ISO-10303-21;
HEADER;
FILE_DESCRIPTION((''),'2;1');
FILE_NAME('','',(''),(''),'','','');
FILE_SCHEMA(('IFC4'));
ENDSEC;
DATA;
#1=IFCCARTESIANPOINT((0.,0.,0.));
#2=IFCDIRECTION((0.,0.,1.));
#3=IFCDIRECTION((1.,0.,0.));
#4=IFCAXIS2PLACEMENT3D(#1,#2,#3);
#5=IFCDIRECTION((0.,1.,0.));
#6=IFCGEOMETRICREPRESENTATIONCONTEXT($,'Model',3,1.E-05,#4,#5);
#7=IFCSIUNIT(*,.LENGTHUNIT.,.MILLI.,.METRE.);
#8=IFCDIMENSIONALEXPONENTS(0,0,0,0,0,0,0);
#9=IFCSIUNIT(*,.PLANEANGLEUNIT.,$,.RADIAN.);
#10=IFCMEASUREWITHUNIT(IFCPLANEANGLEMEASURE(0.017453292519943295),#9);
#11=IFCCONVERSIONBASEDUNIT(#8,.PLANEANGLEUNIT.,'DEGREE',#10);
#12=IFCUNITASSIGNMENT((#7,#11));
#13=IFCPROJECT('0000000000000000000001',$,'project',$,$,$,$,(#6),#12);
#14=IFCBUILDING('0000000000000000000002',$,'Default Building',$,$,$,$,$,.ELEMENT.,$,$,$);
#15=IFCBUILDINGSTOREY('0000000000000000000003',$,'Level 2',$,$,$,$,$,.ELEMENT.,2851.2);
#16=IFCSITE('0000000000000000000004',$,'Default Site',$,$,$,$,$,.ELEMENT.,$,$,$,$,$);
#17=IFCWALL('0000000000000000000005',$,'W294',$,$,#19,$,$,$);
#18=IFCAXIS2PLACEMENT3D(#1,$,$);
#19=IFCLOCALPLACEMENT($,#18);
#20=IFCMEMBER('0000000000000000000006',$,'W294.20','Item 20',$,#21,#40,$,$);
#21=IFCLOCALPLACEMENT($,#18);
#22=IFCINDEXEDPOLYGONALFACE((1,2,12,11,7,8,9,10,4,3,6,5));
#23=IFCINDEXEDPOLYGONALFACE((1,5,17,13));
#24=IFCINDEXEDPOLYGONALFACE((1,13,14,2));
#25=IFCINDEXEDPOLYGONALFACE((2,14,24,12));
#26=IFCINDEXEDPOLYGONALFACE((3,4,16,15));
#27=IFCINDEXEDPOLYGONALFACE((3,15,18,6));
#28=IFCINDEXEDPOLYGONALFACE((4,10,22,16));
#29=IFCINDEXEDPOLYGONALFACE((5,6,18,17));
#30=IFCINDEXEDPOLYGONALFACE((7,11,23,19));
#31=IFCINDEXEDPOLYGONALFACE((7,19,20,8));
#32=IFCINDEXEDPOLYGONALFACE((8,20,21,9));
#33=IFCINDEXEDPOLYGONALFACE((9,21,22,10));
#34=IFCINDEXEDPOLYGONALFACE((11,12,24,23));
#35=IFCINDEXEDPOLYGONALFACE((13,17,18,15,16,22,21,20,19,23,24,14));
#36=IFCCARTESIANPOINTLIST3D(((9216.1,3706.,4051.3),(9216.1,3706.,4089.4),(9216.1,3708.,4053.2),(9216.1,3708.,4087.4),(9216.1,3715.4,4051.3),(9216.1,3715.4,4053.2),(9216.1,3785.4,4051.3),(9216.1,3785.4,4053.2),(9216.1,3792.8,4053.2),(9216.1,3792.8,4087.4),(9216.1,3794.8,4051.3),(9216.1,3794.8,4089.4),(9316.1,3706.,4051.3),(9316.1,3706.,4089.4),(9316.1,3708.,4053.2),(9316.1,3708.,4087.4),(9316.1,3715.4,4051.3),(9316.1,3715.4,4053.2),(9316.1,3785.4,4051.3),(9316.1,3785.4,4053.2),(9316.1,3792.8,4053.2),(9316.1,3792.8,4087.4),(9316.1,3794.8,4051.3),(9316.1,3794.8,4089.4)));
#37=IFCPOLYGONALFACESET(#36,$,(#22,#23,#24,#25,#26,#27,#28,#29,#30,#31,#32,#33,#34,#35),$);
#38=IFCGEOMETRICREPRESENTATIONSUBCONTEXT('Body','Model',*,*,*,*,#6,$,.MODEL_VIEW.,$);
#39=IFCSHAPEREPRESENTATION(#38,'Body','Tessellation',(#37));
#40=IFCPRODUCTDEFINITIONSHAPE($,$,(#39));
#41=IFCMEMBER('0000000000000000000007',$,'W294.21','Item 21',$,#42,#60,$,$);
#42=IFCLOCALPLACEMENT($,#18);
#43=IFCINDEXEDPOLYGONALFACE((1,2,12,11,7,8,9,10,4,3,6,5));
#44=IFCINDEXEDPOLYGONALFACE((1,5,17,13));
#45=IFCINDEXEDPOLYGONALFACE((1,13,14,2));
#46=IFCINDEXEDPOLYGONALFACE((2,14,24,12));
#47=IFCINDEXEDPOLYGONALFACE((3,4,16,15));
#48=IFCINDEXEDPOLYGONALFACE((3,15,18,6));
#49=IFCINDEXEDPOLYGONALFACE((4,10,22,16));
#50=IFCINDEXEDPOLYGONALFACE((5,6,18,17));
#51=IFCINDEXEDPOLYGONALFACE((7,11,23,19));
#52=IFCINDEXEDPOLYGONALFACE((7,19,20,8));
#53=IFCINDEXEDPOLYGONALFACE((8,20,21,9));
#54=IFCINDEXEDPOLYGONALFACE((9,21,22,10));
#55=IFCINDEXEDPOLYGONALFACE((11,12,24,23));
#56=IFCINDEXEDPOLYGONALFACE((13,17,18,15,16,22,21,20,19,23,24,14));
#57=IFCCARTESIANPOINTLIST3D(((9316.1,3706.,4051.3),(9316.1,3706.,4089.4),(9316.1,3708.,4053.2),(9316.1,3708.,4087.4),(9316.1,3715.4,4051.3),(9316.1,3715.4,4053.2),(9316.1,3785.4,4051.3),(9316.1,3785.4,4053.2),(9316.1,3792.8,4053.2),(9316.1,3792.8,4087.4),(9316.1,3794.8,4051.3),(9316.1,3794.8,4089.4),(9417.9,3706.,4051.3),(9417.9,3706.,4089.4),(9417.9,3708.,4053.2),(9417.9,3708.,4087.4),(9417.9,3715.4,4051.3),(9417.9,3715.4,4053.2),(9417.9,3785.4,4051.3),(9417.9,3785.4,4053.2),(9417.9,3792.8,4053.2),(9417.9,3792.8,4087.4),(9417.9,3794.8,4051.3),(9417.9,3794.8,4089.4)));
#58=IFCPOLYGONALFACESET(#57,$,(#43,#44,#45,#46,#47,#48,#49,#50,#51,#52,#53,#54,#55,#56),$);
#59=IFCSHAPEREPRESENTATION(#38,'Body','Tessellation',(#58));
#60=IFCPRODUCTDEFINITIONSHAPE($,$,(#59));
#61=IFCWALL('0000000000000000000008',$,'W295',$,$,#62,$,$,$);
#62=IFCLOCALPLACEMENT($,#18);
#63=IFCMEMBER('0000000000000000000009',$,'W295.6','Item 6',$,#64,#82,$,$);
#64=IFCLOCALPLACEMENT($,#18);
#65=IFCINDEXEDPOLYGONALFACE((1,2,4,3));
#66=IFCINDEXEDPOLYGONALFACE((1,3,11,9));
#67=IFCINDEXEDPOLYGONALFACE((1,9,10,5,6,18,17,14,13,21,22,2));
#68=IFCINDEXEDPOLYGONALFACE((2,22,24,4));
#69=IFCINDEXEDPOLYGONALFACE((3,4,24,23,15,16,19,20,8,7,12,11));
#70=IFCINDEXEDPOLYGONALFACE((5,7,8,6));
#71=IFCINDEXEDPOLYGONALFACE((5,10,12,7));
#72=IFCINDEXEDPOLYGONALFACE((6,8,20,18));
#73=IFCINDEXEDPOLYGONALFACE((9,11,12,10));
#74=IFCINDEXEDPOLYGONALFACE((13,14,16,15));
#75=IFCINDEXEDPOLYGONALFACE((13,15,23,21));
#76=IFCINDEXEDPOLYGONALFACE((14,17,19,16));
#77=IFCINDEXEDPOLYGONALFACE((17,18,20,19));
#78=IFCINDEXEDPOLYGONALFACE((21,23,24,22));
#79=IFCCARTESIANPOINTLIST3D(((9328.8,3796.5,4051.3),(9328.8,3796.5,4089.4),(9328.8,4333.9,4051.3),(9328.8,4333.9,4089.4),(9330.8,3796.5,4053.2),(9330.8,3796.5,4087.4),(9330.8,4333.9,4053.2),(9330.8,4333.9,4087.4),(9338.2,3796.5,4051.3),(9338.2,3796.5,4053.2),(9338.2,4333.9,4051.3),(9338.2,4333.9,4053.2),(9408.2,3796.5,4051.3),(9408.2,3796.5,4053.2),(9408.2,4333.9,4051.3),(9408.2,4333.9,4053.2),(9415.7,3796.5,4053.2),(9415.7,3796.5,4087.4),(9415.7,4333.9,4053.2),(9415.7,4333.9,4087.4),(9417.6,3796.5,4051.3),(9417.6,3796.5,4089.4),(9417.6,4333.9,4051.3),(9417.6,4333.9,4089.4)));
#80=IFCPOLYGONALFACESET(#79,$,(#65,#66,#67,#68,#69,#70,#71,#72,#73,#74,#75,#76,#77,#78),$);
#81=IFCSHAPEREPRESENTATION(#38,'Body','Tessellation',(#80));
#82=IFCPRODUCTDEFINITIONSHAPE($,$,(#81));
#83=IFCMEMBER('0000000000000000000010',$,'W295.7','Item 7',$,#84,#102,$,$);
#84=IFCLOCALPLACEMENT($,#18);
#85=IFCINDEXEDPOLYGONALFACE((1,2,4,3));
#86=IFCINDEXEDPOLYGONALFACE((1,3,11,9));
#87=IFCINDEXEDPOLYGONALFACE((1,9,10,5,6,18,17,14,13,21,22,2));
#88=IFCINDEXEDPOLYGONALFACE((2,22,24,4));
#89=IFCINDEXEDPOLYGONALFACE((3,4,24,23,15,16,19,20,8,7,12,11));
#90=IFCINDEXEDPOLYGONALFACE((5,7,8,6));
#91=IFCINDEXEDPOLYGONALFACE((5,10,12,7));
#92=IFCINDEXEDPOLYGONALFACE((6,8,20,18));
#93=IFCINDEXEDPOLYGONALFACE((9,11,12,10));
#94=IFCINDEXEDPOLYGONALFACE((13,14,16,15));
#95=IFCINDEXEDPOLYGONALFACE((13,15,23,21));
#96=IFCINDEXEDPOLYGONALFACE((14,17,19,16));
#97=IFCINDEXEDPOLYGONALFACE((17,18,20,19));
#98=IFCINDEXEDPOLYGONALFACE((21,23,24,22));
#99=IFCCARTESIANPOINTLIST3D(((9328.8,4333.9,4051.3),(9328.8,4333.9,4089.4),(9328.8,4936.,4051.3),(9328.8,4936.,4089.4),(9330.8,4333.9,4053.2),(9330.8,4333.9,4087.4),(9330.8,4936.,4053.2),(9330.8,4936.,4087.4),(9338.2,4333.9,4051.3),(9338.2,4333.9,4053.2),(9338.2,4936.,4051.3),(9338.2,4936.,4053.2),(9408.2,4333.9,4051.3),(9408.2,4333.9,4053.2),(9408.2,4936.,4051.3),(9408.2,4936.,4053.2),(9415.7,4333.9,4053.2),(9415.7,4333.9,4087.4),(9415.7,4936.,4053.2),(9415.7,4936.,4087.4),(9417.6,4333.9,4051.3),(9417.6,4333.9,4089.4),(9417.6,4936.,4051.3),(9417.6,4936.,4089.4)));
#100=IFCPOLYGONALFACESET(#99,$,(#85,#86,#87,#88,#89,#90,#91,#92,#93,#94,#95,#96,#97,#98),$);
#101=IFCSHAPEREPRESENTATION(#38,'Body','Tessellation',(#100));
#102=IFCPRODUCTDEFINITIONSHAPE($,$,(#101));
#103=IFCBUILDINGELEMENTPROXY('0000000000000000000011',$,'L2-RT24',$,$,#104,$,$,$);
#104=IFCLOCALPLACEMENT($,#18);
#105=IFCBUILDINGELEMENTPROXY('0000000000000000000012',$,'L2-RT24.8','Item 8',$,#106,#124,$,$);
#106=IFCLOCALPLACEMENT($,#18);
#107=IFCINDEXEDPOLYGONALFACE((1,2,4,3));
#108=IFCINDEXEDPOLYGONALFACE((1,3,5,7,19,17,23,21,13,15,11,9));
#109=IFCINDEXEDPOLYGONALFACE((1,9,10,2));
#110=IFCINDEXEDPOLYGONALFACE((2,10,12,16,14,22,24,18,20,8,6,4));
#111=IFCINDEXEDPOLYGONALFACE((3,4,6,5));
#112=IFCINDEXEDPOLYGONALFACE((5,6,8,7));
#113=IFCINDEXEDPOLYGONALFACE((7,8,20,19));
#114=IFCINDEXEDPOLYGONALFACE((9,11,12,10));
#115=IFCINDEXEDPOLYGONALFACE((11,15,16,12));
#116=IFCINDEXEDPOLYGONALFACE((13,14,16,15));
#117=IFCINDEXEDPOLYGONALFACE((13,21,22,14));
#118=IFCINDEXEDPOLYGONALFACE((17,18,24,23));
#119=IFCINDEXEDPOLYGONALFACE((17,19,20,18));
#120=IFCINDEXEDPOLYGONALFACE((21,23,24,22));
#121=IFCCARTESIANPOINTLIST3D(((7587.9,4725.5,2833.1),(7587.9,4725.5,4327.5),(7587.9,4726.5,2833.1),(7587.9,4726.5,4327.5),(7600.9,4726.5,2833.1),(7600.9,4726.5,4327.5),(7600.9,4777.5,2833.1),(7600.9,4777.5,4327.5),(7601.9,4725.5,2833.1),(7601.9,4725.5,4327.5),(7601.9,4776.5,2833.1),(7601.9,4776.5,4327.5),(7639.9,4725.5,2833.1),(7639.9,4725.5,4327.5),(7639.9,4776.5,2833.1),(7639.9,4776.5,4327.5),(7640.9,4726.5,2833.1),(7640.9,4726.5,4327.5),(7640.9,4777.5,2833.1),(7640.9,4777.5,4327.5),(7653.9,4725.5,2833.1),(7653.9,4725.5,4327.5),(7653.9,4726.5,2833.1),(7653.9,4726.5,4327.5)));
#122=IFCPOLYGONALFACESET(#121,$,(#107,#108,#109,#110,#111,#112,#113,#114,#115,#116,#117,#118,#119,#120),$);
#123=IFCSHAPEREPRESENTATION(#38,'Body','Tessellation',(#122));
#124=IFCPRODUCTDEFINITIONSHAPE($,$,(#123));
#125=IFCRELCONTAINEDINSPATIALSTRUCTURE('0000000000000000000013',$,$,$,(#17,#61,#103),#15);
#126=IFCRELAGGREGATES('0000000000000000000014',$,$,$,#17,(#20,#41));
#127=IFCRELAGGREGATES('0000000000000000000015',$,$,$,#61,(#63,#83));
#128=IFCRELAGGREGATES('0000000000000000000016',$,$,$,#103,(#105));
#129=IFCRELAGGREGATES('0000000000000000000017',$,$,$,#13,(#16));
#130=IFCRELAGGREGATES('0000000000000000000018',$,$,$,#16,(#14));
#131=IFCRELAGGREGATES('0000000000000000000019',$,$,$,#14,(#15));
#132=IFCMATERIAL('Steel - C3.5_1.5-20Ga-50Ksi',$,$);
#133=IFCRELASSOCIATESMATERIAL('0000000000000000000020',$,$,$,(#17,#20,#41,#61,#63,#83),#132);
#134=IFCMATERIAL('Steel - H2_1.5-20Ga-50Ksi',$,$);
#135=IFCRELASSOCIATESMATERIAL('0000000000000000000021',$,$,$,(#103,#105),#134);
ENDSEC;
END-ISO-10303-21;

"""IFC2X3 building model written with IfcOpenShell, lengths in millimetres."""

from ifc_helpers import new_model, entity, si_unit, converted_unit, direction, frame, origin, origin_with_axes, origin_2d_with_axis, place, context, subcontext, project, spatial, polyline, c_section, outline, extrude, material, element, aggregate, save


model = new_model("IFC2X3")

# Units and contexts
model_context = context("Model", 3, precision=1e-05, world=origin_with_axes(), true_north=direction((0.0, 1.0, 0.0)))
body_context = subcontext(model_context, "Body", "Model", "MODEL_VIEW")
ifc_project = project(units=[si_unit("LENGTHUNIT", "METRE", prefix="MILLI"), converted_unit("PLANEANGLEUNIT", "DEGREE", entity("IfcPlaneAngleMeasure", 0.017453292519943295), si_unit("PLANEANGLEUNIT", "RADIAN"), dimensions=[0, 0, 0, 0, 0, 0, 0])], contexts=[model_context])

# Site, building, storey
site = spatial("IfcSite", under=ifc_project, Name="Default Site", CompositionType="ELEMENT")
building = spatial("IfcBuilding", under=site, Name="Default Building", CompositionType="ELEMENT")
storey = spatial("IfcBuildingStorey", under=building, Name="Level 2", CompositionType="ELEMENT", Elevation=2851.2)

# Shared definitions
ifc_material_1 = material(Name="Steel - C3.5_1.5-20Ga-50Ksi")

# Walls, members
wall_1 = element("IfcWall", 1, inside=storey, material=ifc_material_1, Name="W294")
member_1_placement = place(None, frame((9316.1, 3750.4, 4070.3), z_axis=(-1.0, 0.0, 0.0), x_axis=(0.0, 0.0, -1.0)))
member_1 = element("IfcMember", 2, at=member_1_placement, material=ifc_material_1, Name="W294.20", Description="Item 20", context=body_context, shape_type="SweptSolid", body=[
    extrude(c_section(Depth=88.9, Width=38.1, WallThickness=2.0, Girth=9.5, at=origin_2d_with_axis()), origin(), (0.0, 0.0, 1.0), 100.0),
])
member_2_placement = place(None, frame((9417.9, 3750.4, 4070.3), z_axis=(-1.0, 0.0, 0.0), x_axis=(0.0, 0.0, -1.0)))
member_2 = element("IfcMember", 3, at=member_2_placement, material=ifc_material_1, Name="W294.21", Description="Item 21", context=body_context, shape_type="SweptSolid", body=[
    extrude(c_section(Depth=88.9, Width=38.1, WallThickness=2.0, Girth=9.5, at=origin_2d_with_axis()), origin(), (0.0, 0.0, 1.0), 101.8),
])
aggregate(wall_1, [member_1, member_2])
wall_2 = element("IfcWall", 4, inside=storey, material=ifc_material_1, Name="W295")
member_3_placement = place(None, frame((9373.2, 4333.9, 4070.3), z_axis=(0.0, -1.0, 0.0), x_axis=(0.0, 0.0, -1.0)))
member_3 = element("IfcMember", 5, at=member_3_placement, material=ifc_material_1, Name="W295.6", Description="Item 6", context=body_context, shape_type="SweptSolid", body=[
    extrude(c_section(Depth=88.9, Width=38.1, WallThickness=2.0, Girth=9.5, at=origin_2d_with_axis()), origin(), (0.0, 0.0, 1.0), 537.4),
])
member_4_placement = place(None, frame((9373.2, 4936.0, 4070.3), z_axis=(0.0, -1.0, 0.0), x_axis=(0.0, 0.0, -1.0)))
member_4 = element("IfcMember", 6, at=member_4_placement, material=ifc_material_1, Name="W295.7", Description="Item 7", context=body_context, shape_type="SweptSolid", body=[
    extrude(c_section(Depth=88.9, Width=38.1, WallThickness=2.0, Girth=9.5, at=origin_2d_with_axis()), origin(), (0.0, 0.0, 1.0), 602.1),
])
aggregate(wall_2, [member_3, member_4])

# Building element proxies
ifc_material_2 = material(Name="Steel - H2_1.5-20Ga-50Ksi")
proxy_1 = element("IfcBuildingElementProxy", 7, inside=storey, material=ifc_material_2, Name="L2-RT24")
proxy_2_placement = place(None, frame((7653.9, 4725.5, 4327.5), z_axis=(0.0, 0.0, -1.0), x_axis=(-40.0, 0.0, 0.0)))
proxy_2 = element("IfcBuildingElementProxy", 8, at=proxy_2_placement, material=ifc_material_2, Name="L2-RT24.8", Description="Item 8", context=body_context, shape_type="SweptSolid", body=[
    extrude(outline(polyline([(0.0, 0.0), (14.0, 0.0), (14.0, 51.0), (52.0, 51.0), (52.0, 0.0), (66.0, 0.0), (66.0, 1.0), (53.0, 1.0), (53.0, 52.0), (13.0, 52.0), (13.0, 1.0), (0.0, 1.0), (0.0, 0.0)])), origin(), (0.0, 0.0, 1.0), 1494.4),
])
aggregate(proxy_1, [proxy_2])

save(model, "model.ifc")
